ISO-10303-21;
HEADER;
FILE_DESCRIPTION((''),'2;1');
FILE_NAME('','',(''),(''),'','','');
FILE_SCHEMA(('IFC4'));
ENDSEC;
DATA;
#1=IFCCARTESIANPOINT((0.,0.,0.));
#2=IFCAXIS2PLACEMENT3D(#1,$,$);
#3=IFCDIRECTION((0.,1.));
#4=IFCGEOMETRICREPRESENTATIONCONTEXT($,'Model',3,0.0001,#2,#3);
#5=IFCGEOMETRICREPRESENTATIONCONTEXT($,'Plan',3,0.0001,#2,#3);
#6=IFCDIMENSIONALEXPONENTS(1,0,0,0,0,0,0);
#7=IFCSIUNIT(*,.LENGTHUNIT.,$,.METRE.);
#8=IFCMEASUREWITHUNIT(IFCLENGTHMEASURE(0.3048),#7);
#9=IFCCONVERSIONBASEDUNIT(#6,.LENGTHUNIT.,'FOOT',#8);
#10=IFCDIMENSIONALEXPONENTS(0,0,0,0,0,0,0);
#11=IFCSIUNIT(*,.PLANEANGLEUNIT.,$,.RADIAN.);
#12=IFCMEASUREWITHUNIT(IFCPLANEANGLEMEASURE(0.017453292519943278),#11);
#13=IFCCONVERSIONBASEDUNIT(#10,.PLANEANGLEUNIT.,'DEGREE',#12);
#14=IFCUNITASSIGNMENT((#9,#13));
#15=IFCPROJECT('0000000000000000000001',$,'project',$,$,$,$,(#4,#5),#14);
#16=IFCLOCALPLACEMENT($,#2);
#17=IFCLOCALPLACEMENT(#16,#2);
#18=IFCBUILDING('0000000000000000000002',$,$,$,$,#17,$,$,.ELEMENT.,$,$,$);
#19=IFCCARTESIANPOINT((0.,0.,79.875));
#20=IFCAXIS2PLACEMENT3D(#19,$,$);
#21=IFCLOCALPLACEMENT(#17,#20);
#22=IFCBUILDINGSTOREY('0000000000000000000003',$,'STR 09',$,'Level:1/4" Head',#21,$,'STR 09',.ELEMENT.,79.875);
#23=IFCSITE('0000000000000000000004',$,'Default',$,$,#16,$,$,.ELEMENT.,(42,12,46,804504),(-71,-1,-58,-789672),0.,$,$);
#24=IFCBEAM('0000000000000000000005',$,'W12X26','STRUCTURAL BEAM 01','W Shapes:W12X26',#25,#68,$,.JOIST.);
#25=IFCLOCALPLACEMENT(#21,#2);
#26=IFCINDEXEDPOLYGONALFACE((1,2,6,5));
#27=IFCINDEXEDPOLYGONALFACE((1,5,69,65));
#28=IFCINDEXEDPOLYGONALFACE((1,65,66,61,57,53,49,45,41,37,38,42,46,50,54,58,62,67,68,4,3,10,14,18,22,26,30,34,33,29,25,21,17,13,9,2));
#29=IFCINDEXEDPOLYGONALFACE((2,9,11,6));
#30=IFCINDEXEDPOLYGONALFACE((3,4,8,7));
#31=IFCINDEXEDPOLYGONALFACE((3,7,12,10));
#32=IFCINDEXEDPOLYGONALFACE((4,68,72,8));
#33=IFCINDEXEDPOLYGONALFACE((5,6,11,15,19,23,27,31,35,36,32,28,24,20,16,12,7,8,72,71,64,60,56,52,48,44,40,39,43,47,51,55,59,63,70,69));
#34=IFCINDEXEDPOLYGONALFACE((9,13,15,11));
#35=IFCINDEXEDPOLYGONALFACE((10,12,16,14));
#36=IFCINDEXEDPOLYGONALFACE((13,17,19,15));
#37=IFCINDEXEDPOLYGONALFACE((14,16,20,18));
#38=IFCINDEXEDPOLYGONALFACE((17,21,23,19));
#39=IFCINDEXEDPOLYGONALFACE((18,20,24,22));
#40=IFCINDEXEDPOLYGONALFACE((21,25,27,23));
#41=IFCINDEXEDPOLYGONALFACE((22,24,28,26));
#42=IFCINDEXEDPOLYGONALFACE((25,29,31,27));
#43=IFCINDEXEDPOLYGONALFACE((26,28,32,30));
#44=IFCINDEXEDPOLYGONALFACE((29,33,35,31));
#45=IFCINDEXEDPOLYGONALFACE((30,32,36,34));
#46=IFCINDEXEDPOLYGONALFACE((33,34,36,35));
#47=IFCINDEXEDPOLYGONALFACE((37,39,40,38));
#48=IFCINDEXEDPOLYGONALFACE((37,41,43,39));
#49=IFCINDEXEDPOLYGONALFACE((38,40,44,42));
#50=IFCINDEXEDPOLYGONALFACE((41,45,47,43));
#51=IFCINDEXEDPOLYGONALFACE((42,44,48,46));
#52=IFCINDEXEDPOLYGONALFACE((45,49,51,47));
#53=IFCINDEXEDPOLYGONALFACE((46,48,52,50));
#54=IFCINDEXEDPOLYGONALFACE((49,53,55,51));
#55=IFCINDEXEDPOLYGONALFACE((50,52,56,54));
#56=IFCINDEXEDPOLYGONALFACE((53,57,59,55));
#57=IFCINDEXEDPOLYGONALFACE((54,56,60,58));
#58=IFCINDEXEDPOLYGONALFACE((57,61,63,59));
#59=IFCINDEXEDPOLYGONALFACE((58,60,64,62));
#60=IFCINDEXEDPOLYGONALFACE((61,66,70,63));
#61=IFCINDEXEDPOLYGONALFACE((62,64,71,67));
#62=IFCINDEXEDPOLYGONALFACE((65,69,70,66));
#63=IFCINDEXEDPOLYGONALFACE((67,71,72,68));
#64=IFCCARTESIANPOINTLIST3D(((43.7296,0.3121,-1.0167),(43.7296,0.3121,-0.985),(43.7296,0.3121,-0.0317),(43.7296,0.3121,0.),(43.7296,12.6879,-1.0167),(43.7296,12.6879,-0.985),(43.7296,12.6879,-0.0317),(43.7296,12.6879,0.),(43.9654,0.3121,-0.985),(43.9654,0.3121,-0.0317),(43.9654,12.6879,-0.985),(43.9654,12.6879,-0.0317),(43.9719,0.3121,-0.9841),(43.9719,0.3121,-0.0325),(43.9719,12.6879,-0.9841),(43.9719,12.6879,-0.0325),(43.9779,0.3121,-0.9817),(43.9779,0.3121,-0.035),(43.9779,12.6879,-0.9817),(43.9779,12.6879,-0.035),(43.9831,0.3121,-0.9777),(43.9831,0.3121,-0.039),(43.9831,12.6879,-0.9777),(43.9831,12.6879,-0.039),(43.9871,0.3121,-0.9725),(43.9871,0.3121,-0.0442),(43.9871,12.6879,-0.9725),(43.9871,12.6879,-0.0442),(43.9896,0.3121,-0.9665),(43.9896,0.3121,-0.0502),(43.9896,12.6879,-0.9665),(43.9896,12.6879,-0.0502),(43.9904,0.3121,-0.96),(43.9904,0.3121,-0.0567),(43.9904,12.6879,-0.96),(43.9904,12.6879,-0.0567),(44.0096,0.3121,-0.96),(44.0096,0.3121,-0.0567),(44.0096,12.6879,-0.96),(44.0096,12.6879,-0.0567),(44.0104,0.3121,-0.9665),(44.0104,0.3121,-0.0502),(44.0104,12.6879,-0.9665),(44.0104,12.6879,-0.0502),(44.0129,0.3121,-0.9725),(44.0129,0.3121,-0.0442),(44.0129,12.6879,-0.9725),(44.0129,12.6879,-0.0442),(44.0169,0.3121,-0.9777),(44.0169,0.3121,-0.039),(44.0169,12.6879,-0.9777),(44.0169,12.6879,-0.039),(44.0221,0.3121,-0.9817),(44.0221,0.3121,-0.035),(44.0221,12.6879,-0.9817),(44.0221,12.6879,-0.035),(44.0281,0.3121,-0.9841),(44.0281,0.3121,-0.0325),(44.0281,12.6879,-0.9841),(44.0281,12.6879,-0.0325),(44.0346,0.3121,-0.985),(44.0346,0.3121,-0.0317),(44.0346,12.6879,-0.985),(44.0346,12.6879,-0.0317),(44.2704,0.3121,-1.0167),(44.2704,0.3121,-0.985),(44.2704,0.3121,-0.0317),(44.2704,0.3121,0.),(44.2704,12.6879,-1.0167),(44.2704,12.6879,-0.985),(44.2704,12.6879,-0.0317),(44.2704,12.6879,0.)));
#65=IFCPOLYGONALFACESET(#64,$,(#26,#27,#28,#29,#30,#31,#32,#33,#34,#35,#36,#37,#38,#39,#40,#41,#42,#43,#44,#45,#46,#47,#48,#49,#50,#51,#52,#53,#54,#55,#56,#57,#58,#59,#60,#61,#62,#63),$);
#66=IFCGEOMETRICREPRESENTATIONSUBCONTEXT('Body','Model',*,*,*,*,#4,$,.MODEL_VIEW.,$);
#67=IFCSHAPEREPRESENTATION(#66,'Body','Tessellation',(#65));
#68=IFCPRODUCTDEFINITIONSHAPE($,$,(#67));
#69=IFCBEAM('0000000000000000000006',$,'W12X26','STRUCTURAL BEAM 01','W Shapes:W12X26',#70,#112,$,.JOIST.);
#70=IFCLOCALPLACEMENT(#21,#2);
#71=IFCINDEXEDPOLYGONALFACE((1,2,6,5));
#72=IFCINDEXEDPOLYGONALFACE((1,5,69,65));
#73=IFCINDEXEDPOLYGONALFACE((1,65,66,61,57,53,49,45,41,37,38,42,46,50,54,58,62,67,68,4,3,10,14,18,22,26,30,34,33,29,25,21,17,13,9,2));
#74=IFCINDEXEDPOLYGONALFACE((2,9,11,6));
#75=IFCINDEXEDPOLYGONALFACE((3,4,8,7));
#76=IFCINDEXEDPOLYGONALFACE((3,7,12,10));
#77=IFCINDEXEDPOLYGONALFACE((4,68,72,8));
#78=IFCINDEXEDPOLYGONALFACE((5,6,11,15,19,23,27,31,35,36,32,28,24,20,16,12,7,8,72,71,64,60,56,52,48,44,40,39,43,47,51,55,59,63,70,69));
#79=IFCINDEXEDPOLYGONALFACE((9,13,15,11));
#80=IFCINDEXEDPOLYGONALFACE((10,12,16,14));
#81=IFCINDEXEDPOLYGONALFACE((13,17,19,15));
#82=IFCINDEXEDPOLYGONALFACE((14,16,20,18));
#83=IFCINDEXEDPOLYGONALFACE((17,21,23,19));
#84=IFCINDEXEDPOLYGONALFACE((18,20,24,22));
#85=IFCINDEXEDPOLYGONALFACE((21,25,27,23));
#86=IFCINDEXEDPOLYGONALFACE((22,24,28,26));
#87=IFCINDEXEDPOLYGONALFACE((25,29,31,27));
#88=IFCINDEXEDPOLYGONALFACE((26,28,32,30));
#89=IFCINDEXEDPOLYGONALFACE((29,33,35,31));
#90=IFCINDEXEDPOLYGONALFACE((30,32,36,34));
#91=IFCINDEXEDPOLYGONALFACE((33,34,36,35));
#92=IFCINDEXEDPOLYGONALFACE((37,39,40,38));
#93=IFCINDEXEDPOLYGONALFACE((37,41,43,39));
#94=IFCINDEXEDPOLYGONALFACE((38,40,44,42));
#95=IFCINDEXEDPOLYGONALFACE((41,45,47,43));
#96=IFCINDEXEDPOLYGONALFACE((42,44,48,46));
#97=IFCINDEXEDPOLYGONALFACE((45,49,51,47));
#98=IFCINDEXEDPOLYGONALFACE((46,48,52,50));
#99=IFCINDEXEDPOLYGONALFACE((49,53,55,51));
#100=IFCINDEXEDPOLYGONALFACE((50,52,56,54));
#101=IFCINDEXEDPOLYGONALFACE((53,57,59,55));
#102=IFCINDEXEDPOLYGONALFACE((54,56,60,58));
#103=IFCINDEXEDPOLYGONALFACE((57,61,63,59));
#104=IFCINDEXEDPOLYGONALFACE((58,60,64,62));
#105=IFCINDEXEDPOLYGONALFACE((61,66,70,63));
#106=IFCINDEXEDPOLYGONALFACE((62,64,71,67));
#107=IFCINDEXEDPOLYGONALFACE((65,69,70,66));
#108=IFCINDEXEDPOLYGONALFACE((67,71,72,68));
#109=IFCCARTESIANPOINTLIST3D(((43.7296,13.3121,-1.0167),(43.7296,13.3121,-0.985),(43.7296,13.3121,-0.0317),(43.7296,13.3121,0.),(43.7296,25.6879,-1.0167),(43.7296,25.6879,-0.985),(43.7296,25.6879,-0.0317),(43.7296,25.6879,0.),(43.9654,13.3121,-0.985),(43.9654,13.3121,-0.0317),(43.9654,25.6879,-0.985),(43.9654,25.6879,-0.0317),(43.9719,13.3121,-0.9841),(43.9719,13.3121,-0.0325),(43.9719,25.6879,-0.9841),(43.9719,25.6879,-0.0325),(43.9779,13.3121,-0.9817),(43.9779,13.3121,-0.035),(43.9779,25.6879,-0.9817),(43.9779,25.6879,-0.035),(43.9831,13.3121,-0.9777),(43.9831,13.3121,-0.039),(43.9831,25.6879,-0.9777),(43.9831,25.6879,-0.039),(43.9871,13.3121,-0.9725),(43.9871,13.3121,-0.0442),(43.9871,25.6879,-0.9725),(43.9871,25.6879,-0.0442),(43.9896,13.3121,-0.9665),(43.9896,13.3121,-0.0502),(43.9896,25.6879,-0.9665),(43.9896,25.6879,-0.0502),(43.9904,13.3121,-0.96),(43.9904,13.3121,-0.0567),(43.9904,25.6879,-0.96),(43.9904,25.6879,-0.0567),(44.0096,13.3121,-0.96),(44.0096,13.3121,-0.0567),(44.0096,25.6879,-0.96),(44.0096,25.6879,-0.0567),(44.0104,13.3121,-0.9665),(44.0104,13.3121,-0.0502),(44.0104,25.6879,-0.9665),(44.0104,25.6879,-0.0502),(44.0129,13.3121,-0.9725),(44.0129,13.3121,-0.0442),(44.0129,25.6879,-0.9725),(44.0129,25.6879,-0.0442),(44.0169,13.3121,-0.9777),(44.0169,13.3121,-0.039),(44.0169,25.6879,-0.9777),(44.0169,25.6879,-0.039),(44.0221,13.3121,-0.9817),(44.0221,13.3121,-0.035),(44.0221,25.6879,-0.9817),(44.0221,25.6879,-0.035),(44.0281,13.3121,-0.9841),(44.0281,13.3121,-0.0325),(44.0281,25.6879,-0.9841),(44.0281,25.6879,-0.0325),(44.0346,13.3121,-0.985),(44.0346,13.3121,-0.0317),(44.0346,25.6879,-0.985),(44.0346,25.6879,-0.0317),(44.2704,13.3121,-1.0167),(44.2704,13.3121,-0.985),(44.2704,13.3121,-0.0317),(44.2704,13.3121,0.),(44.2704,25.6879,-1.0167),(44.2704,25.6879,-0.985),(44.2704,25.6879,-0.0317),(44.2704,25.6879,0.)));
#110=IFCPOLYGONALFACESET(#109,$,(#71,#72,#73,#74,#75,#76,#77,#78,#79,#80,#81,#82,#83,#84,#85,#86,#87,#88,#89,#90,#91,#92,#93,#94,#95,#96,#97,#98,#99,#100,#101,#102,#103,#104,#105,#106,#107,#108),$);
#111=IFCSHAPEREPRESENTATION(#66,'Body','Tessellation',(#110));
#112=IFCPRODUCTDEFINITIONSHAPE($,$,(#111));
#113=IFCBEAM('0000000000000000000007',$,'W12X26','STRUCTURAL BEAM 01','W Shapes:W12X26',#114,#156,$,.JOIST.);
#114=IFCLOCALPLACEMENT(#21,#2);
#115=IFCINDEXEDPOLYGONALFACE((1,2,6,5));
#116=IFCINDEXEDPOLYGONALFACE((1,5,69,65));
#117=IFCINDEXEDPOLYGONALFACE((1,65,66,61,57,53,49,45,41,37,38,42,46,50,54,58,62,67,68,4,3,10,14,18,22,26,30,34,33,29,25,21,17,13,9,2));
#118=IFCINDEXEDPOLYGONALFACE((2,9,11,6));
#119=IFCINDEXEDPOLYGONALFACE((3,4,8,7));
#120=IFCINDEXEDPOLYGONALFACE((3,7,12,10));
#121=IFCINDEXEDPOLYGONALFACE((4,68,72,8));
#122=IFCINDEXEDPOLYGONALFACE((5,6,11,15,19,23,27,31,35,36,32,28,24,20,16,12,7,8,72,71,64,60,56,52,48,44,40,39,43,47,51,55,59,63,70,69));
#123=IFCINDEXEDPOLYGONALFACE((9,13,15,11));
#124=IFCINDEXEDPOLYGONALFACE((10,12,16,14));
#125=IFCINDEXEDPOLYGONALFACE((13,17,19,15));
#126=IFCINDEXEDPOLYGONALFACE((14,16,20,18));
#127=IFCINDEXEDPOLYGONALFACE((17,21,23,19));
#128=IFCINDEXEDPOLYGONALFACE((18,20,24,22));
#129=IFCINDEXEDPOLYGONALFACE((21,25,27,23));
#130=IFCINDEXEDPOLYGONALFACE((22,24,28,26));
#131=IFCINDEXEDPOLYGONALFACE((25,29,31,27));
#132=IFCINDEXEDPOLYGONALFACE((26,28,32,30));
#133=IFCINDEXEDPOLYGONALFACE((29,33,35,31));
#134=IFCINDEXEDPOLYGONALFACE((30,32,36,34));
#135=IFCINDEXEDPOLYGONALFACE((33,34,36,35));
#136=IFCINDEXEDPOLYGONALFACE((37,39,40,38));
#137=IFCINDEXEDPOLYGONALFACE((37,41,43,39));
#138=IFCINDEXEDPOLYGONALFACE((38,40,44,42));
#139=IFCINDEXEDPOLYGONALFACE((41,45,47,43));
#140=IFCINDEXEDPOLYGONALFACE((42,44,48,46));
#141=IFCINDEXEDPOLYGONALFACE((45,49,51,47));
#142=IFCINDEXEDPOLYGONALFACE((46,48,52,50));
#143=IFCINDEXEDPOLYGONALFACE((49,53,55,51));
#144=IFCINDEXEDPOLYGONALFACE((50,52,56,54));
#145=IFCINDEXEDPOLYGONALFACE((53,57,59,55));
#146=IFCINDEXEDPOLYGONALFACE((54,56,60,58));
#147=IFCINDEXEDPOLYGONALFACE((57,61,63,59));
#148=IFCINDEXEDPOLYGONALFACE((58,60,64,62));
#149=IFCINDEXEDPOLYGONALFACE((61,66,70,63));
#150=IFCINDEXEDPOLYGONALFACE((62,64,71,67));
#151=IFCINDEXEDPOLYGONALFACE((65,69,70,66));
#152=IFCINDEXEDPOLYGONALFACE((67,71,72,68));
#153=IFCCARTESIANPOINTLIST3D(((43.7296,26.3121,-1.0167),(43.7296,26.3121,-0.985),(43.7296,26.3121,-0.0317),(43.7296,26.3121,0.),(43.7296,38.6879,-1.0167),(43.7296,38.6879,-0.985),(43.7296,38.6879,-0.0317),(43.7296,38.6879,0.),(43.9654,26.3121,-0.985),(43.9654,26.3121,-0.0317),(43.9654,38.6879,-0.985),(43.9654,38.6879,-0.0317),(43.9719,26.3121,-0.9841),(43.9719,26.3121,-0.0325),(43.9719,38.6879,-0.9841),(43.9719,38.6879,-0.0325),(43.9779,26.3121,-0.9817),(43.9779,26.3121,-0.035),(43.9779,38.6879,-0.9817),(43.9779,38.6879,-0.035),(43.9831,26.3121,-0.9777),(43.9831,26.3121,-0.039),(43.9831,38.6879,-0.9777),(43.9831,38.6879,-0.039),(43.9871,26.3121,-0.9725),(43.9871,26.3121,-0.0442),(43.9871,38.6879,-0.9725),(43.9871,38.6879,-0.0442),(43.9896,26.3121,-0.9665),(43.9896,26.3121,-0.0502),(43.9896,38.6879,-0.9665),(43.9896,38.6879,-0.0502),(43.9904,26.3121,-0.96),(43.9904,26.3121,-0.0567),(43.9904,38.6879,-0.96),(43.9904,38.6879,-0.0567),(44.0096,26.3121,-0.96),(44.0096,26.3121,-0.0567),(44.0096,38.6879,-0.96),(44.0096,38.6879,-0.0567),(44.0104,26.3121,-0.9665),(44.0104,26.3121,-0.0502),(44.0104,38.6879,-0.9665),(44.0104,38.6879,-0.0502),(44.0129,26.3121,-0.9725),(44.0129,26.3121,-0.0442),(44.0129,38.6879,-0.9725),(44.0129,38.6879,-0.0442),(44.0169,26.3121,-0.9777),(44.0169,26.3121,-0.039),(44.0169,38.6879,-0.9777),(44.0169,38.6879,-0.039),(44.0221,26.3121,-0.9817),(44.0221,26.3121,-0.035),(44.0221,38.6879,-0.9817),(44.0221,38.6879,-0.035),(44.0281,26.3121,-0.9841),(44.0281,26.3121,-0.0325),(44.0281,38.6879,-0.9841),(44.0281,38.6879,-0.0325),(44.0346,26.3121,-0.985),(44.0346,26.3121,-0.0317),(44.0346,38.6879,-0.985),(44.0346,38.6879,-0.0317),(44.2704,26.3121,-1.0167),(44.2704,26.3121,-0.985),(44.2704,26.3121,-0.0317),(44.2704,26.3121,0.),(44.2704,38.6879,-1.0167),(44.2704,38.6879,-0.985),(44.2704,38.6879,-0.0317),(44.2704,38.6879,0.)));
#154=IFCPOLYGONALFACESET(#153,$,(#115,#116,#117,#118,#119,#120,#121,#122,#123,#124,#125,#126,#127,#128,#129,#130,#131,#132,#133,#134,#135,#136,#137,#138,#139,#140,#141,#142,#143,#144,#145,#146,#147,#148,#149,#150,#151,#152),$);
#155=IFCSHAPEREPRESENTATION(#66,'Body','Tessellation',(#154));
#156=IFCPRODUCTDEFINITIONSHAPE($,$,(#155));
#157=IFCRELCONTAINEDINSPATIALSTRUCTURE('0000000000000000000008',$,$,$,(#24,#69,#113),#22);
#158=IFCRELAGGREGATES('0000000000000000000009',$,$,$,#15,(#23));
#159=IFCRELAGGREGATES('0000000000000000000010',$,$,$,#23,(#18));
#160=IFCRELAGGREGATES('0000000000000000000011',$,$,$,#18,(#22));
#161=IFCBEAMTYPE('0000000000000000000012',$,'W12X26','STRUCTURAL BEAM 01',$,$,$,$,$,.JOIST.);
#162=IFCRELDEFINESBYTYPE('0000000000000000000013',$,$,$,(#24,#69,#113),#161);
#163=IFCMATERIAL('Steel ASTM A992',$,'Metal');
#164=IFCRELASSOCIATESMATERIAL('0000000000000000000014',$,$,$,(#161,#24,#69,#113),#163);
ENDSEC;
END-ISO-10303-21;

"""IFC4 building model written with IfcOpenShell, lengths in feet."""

from ifc_helpers import new_model, entity, si_unit, converted_unit, direction, frame, origin, place, context, subcontext, project, spatial, line, arc, indexed_curve, outline, extrude, source, transform, mapped, material, type_object, type_shapes, element, save


model = new_model("IFC4")

# Units and contexts
model_context = context("Model", 3, precision=0.0001, world=origin(), true_north=direction((0.0, 1.0)))
plan_context = context("Plan", 3, precision=0.0001, world=origin(), true_north=direction((0.0, 1.0)))
body_context = subcontext(model_context, "Body", "Model", "MODEL_VIEW")
ifc_project = project(units=[converted_unit("LENGTHUNIT", "FOOT", entity("IfcLengthMeasure", 0.3048), si_unit("LENGTHUNIT", "METRE"), dimensions=[1, 0, 0, 0, 0, 0, 0]), converted_unit("PLANEANGLEUNIT", "DEGREE", entity("IfcPlaneAngleMeasure", 0.017453292519943278), si_unit("PLANEANGLEUNIT", "RADIAN"), dimensions=[0, 0, 0, 0, 0, 0, 0])], contexts=[model_context, plan_context])

# Site, building, storey
site_placement = place(None, origin())
site = spatial("IfcSite", under=ifc_project, at=site_placement, Name="Default", CompositionType="ELEMENT", RefLatitude=(42, 12, 46, 804504), RefLongitude=(-71, -1, -58, -789672), RefElevation=0.0)
building_placement = place(site_placement, origin())
building = spatial("IfcBuilding", under=site, at=building_placement, CompositionType="ELEMENT")
storey_placement = place(building_placement, frame((0.0, 0.0, 79.875)))
storey = spatial("IfcBuildingStorey", under=building, at=storey_placement, Name="STR 09", ObjectType="Level:1/4\" Head", LongName="STR 09", CompositionType="ELEMENT", Elevation=79.875)

# Shared definitions
ifc_material = material(Name="Steel ASTM A992", Category="Metal")

# Shared definitions
beam_type_1 = type_object("IfcBeamType", Name="W12X26", Description="STRUCTURAL BEAM 01", PredefinedType="JOIST", material=ifc_material)
shared_shape_1 = source(origin(), body_context, "Body", "SweptSolid", [
    extrude(outline(indexed_curve([(-0.2704, -0.4767), (-0.2704, -0.5083), (0.2704, -0.5083), (0.2704, -0.4767), (0.0346, -0.4767), (0.0169, -0.4693), (0.0096, -0.4517), (0.0096, 0.4517), (0.0169, 0.4693), (0.0346, 0.4767), (0.2704, 0.4767), (0.2704, 0.5083), (-0.2704, 0.5083), (-0.2704, 0.4767), (-0.0346, 0.4767), (-0.0169, 0.4693), (-0.0096, 0.4517), (-0.0096, -0.4517), (-0.0169, -0.4693), (-0.0346, -0.4767)], segments=[line(1, 2, 3, 4, 5), arc(5, 6, 7), line(7, 8), arc(8, 9, 10), line(10, 11, 12, 13, 14, 15), arc(15, 16, 17), line(17, 18), arc(18, 19, 20), line(20, 1)], self_intersect=False)), frame((-6.1879, 0.0, 0.0), z_axis=(-1.0, 0.0, 0.0), x_axis=(0.0, -1.0, 0.0)), (0.0, 0.0, -1.0), 12.3758),
])
type_shapes(beam_type_1, [shared_shape_1])

# Beams
for number, where, z_axis, x_axis, name in (
    (1, (44.0, 6.5, -0.5083), (0.0, 0.0, 1.0), (0.0, 1.0, 0.0), "W12X26"),
    (2, (44.0, 19.5, -0.5083), (0.0, 0.0, 1.0), (0.0, 1.0, 0.0), "W12X26"),
    (3, (44.0, 32.5, -0.5083), (0.0, 0.0, 1.0), (0.0, 1.0, 0.0), "W12X26"),
):
    element("IfcBeam", number, at=place(storey_placement, frame(where, z_axis=z_axis, x_axis=x_axis)), inside=storey, type_object=beam_type_1, material=ifc_material, Name=name, Description="STRUCTURAL BEAM 01", ObjectType="W Shapes:W12X26", PredefinedType="JOIST", context=body_context, shape_type="MappedRepresentation", body=[
        mapped(shared_shape_1, transform((0.0, 0.0, 0.0), scale=1.0)),
    ])

save(model, "model.ifc")
